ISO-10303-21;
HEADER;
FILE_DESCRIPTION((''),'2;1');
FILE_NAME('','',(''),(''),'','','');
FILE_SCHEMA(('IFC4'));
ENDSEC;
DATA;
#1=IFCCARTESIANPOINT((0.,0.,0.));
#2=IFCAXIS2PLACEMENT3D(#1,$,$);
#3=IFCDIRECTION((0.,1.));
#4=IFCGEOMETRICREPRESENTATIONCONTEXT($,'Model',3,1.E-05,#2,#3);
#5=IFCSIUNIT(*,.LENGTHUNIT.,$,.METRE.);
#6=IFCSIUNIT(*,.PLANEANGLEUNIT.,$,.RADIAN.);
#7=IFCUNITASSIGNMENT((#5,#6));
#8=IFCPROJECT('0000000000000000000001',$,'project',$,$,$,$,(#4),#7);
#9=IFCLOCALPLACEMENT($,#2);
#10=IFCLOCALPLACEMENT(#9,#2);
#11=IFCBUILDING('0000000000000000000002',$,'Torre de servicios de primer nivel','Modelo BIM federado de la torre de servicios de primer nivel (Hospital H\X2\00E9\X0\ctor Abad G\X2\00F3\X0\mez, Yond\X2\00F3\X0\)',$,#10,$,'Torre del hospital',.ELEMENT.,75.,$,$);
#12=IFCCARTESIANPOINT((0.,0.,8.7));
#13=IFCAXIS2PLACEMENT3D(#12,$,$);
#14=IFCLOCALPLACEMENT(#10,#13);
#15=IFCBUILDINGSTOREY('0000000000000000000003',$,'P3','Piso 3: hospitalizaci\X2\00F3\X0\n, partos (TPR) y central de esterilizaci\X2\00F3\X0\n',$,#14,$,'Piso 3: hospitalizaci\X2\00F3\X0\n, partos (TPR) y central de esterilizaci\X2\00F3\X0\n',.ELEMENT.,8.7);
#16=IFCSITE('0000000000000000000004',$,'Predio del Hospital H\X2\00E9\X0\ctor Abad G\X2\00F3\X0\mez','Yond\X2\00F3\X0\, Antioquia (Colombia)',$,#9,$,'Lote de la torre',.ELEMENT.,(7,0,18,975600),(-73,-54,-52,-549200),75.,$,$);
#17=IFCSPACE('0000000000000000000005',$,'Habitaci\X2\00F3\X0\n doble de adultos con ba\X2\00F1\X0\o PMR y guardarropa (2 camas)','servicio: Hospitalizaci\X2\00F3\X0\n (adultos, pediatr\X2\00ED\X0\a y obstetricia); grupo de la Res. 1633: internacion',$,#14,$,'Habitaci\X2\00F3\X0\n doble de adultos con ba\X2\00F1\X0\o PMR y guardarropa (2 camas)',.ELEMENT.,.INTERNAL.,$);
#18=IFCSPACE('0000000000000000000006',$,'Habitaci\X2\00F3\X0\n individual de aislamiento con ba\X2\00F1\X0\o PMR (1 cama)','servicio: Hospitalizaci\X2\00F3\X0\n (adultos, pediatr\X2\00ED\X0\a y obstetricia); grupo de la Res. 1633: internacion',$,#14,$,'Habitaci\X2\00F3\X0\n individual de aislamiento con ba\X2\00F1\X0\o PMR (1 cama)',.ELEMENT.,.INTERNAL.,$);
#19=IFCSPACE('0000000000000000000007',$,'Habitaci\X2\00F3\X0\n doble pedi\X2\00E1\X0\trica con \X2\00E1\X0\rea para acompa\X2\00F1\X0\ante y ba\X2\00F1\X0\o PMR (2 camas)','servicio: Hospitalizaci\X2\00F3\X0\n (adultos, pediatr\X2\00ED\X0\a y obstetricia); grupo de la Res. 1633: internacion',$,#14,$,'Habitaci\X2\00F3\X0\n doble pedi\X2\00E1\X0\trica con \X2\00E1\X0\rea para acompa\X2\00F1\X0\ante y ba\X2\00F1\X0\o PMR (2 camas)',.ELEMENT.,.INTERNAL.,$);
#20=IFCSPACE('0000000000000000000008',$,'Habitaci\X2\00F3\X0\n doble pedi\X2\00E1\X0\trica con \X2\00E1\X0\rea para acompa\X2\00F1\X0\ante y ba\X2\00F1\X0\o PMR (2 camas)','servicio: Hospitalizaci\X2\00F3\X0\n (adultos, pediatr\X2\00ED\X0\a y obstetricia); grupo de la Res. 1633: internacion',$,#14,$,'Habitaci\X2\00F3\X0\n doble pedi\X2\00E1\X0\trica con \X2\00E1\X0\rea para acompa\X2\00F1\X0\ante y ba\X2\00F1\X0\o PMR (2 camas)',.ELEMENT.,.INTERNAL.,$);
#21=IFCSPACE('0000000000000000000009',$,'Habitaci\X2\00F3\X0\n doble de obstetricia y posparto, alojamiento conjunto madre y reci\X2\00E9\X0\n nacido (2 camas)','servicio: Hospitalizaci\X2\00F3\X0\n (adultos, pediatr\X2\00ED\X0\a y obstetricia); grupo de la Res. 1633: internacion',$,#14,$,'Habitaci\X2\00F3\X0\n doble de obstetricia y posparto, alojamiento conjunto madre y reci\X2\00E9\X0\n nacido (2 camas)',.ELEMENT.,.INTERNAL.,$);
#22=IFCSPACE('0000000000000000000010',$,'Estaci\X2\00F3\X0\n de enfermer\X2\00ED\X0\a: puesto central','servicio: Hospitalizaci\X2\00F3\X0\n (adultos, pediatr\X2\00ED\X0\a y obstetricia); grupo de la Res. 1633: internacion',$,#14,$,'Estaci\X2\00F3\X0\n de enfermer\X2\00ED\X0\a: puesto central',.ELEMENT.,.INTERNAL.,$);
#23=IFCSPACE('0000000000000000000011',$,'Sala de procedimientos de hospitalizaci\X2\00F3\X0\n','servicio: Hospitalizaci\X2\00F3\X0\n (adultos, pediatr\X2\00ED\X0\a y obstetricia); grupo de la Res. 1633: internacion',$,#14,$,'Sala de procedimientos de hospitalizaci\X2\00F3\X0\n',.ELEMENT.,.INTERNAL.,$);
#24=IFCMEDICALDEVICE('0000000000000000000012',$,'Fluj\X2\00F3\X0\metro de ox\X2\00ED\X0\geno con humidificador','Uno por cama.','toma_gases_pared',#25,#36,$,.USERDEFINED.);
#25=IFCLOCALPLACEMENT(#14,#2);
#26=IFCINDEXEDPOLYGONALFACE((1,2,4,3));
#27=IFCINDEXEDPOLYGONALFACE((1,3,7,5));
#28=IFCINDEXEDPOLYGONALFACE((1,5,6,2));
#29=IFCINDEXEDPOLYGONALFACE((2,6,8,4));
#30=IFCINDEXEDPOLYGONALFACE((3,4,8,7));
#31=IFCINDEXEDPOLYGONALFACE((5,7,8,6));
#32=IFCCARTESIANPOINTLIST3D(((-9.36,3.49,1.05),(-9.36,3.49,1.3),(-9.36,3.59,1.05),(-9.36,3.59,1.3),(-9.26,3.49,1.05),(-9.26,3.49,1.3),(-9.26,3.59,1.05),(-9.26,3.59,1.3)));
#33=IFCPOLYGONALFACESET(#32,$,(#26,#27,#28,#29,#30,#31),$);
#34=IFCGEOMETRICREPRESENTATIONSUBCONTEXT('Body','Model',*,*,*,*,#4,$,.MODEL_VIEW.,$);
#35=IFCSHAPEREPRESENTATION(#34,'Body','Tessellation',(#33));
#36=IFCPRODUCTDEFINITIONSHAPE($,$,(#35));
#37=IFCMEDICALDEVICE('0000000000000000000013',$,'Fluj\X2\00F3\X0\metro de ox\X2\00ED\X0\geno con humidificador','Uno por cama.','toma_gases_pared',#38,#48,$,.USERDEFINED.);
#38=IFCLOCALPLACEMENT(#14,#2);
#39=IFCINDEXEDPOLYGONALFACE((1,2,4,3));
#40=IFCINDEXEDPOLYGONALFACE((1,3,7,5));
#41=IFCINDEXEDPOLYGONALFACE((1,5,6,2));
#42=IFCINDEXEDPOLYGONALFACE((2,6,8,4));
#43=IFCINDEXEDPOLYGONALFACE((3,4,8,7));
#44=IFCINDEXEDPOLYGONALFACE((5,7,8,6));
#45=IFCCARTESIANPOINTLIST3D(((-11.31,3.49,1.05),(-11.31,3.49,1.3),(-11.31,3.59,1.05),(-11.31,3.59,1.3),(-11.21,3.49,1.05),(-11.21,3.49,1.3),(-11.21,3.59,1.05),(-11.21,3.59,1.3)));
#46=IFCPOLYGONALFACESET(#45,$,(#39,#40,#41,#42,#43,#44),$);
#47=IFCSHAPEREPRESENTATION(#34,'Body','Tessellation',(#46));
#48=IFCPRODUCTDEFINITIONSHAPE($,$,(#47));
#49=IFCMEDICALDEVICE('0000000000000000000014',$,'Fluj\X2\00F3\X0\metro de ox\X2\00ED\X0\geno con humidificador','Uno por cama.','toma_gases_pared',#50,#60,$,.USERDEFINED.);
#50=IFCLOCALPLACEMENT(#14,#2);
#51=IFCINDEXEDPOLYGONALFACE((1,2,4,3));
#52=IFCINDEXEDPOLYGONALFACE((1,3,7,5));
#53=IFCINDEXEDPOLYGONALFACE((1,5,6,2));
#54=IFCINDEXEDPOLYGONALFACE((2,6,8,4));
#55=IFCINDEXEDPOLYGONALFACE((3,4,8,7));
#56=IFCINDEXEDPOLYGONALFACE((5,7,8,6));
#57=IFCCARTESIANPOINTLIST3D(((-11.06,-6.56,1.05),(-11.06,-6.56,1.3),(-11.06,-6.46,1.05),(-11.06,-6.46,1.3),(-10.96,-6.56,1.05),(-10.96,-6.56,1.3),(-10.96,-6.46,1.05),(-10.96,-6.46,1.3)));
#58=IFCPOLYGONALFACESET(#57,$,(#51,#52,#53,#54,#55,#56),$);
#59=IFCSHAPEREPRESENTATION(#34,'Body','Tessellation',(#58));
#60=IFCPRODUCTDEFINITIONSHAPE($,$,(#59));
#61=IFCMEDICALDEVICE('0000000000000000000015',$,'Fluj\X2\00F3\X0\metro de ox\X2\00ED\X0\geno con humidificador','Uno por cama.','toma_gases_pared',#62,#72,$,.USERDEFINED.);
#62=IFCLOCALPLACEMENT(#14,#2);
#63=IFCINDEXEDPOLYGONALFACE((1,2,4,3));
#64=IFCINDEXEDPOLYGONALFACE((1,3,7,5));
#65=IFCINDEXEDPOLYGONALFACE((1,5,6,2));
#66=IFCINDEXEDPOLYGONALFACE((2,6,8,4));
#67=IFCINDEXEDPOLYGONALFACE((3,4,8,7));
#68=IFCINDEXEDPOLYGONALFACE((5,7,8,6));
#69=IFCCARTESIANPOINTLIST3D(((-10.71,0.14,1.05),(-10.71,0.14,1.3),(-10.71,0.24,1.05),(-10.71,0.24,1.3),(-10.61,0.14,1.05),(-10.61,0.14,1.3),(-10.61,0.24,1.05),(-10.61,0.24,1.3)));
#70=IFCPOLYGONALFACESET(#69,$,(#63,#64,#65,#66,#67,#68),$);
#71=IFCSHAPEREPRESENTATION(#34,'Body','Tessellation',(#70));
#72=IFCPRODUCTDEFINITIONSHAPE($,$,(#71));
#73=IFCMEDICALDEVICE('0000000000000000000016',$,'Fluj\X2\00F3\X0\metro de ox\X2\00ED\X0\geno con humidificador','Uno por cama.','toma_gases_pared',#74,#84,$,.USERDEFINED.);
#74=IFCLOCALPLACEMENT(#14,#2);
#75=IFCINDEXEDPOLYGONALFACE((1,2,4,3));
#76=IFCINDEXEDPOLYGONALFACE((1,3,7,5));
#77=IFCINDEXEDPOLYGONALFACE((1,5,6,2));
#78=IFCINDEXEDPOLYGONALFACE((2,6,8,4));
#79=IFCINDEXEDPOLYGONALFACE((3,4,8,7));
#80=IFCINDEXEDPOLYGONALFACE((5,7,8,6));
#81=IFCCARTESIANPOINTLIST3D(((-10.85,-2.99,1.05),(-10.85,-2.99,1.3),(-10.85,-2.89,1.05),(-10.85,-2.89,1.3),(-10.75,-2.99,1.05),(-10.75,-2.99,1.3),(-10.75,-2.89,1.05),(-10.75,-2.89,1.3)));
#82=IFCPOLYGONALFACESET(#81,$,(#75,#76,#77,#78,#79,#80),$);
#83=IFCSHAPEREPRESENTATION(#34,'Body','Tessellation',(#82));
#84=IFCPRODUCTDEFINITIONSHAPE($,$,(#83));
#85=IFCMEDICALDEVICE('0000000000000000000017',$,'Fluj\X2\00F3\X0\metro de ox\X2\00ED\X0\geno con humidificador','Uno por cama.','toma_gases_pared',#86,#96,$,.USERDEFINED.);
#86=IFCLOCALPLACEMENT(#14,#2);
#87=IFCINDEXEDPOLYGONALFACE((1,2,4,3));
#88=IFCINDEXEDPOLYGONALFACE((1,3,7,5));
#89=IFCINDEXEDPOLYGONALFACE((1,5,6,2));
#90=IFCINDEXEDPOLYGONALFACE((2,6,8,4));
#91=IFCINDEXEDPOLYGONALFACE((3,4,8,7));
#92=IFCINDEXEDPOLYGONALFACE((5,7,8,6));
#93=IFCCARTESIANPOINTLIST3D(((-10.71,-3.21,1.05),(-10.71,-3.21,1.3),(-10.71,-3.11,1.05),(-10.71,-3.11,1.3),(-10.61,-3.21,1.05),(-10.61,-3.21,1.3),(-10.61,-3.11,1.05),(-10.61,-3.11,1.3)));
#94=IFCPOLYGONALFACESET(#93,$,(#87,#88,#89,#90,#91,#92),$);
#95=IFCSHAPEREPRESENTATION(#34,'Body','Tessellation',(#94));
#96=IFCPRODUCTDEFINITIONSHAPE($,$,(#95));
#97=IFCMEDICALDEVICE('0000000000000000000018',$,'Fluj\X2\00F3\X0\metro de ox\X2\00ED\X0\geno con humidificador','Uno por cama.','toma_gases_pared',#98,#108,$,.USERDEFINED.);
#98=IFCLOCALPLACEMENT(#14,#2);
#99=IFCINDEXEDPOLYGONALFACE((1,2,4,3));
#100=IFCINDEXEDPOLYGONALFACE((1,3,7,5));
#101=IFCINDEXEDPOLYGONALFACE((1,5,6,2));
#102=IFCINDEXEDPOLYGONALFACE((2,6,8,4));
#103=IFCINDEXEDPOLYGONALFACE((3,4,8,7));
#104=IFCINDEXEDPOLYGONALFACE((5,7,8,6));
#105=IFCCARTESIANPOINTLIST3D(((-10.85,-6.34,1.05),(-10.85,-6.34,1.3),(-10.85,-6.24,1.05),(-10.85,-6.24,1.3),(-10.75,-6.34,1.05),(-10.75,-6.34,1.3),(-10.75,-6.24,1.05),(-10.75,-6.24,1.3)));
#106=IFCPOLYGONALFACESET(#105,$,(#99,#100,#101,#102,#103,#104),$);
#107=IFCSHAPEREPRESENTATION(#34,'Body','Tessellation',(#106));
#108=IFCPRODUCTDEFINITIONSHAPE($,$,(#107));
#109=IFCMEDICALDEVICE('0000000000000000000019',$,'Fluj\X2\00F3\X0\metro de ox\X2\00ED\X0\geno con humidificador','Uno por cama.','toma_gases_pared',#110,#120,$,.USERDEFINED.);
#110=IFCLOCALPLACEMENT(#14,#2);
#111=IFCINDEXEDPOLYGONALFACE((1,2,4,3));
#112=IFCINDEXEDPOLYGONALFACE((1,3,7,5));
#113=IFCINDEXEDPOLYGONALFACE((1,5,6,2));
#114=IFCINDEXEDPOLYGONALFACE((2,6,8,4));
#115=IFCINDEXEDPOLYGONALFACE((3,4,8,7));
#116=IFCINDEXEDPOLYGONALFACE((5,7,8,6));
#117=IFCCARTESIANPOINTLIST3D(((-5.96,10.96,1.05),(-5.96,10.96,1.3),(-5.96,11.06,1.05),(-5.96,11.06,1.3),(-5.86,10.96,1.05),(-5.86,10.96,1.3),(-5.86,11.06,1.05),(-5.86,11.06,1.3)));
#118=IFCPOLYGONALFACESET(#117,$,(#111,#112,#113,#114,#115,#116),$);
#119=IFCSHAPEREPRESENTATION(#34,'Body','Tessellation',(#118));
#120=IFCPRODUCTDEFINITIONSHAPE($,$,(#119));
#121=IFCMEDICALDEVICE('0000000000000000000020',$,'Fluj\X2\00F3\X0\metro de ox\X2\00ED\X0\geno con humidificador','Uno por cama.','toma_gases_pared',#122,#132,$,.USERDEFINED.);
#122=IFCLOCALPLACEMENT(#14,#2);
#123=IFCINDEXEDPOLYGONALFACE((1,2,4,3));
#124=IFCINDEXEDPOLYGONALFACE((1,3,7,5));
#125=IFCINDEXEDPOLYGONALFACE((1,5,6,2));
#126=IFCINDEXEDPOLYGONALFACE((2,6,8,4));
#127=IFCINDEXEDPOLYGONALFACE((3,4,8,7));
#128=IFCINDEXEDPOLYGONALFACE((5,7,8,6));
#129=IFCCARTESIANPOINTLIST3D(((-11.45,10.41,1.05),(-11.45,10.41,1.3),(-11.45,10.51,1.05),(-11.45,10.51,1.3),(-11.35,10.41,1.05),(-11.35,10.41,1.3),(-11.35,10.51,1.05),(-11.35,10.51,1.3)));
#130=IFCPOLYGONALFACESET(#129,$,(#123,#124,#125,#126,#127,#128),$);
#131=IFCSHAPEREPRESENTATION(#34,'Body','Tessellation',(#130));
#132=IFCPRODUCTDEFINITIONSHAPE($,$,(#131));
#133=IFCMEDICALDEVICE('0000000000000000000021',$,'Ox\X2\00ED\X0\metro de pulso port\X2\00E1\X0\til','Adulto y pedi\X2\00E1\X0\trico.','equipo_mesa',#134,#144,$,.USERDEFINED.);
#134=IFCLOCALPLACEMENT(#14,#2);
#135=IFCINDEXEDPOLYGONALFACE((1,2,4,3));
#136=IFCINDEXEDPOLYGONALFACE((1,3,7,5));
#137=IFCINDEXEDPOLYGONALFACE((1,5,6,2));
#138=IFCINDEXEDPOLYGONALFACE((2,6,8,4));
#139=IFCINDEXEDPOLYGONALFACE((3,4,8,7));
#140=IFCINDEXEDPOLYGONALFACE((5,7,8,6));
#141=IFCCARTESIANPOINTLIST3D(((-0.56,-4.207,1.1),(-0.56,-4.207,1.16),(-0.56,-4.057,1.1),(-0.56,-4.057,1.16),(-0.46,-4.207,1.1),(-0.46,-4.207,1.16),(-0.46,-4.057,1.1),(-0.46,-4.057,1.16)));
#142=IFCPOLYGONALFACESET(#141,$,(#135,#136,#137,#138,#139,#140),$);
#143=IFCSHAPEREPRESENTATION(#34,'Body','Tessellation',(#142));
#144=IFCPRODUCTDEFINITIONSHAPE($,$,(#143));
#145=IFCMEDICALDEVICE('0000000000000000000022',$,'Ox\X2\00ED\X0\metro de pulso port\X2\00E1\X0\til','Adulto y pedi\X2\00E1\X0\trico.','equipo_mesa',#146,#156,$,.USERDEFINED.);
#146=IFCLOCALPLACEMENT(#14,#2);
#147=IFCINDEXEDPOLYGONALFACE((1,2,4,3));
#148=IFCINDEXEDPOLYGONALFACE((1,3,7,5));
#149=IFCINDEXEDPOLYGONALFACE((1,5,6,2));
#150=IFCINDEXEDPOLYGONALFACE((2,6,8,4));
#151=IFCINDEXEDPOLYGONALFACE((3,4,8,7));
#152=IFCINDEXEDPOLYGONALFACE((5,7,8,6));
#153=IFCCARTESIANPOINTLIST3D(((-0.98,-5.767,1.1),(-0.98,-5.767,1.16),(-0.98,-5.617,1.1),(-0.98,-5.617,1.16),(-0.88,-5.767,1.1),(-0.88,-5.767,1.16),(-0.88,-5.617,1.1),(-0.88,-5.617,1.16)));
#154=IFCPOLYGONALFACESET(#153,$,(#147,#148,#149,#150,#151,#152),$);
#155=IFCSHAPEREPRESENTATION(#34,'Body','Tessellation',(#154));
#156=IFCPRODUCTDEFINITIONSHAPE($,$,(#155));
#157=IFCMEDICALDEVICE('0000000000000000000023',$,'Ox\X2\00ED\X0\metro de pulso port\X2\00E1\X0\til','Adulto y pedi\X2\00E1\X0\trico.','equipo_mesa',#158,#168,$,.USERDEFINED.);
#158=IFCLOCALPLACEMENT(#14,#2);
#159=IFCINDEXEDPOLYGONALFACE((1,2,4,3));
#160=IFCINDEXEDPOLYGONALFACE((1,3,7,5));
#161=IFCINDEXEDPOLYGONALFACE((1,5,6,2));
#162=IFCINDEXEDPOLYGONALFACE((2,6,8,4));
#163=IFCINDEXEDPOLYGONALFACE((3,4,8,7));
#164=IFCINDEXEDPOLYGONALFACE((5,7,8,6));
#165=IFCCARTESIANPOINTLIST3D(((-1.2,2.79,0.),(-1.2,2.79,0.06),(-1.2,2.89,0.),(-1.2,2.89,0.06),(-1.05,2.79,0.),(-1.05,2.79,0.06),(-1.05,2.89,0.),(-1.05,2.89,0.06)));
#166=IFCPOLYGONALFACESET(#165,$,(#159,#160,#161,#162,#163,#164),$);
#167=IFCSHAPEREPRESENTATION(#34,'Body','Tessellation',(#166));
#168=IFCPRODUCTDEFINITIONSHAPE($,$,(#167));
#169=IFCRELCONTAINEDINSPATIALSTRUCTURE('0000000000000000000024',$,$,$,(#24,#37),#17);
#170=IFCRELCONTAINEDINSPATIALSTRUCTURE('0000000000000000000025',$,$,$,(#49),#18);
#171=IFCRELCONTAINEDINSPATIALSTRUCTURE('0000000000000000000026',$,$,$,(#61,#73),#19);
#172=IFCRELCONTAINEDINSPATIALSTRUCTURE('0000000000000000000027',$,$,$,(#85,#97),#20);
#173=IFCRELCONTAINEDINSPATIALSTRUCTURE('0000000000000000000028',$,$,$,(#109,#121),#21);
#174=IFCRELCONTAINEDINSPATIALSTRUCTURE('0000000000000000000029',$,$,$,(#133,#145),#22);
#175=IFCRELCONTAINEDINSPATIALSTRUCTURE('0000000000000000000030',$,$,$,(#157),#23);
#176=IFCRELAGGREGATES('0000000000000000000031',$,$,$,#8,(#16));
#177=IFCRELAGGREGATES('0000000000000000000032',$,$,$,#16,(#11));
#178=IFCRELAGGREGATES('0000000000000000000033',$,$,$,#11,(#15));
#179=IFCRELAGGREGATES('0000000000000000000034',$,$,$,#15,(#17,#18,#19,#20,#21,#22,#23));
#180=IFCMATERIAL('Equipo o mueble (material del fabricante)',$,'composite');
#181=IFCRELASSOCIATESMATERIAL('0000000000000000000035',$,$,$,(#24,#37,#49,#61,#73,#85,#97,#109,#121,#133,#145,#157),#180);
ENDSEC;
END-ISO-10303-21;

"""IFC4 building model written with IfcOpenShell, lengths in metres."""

from ifc_helpers import new_model, si_unit, direction, frame, origin, place, context, subcontext, project, spatial, rectangle, extrude, material, element, save


model = new_model("IFC4")

# Units and contexts
model_context = context("Model", 3, precision=1e-05, world=origin(), true_north=direction((0.0, 1.0)))
body_context = subcontext(model_context, "Body", "Model", "MODEL_VIEW")
ifc_project = project(units=[si_unit("LENGTHUNIT", "METRE"), si_unit("PLANEANGLEUNIT", "RADIAN")], contexts=[model_context])

# Site, building, storey
site_placement = place(None, origin())
site = spatial("IfcSite", under=ifc_project, at=site_placement, Name="Predio del Hospital Héctor Abad Gómez", Description="Yondó, Antioquia (Colombia)", LongName="Lote de la torre", CompositionType="ELEMENT", RefLatitude=(7, 0, 18, 975600), RefLongitude=(-73, -54, -52, -549200), RefElevation=75.0)
building_placement = place(site_placement, origin())
building = spatial("IfcBuilding", under=site, at=building_placement, Name="Torre de servicios de primer nivel", Description="Modelo BIM federado de la torre de servicios de primer nivel (Hospital Héctor Abad Gómez, Yondó)", LongName="Torre del hospital", CompositionType="ELEMENT", ElevationOfRefHeight=75.0)
placement = place(building_placement, frame((0.0, 0.0, 8.7)))
storey = spatial("IfcBuildingStorey", under=building, at=placement, Name="P3", Description="Piso 3: hospitalización, partos (TPR) y central de esterilización", LongName="Piso 3: hospitalización, partos (TPR) y central de esterilización", CompositionType="ELEMENT", Elevation=8.7)

# Shared definitions
ifc_material = material(Name="Equipo o mueble (material del fabricante)", Category="composite")

# Shared definitions
space_1 = spatial("IfcSpace", under=storey, at=placement, Name="Habitación doble de adultos con baño PMR y guardarropa (2 camas)", Description="servicio: Hospitalización (adultos, pediatría y obstetricia); grupo de la Res. 1633: internacion", LongName="Habitación doble de adultos con baño PMR y guardarropa (2 camas)", CompositionType="ELEMENT", PredefinedType="INTERNAL")

# Shared definitions
space_2 = spatial("IfcSpace", under=storey, at=placement, Name="Habitación individual de aislamiento con baño PMR (1 cama)", Description="servicio: Hospitalización (adultos, pediatría y obstetricia); grupo de la Res. 1633: internacion", LongName="Habitación individual de aislamiento con baño PMR (1 cama)", CompositionType="ELEMENT", PredefinedType="INTERNAL")

# Shared definitions
space_3 = spatial("IfcSpace", under=storey, at=placement, Name="Habitación doble pediátrica con área para acompañante y baño PMR (2 camas)", Description="servicio: Hospitalización (adultos, pediatría y obstetricia); grupo de la Res. 1633: internacion", LongName="Habitación doble pediátrica con área para acompañante y baño PMR (2 camas)", CompositionType="ELEMENT", PredefinedType="INTERNAL")

# Shared definitions
space_4 = spatial("IfcSpace", under=storey, at=placement, Name="Habitación doble pediátrica con área para acompañante y baño PMR (2 camas)", Description="servicio: Hospitalización (adultos, pediatría y obstetricia); grupo de la Res. 1633: internacion", LongName="Habitación doble pediátrica con área para acompañante y baño PMR (2 camas)", CompositionType="ELEMENT", PredefinedType="INTERNAL")

# Shared definitions
space_5 = spatial("IfcSpace", under=storey, at=placement, Name="Habitación doble de obstetricia y posparto, alojamiento conjunto madre y recién nacido (2 camas)", Description="servicio: Hospitalización (adultos, pediatría y obstetricia); grupo de la Res. 1633: internacion", LongName="Habitación doble de obstetricia y posparto, alojamiento conjunto madre y recién nacido (2 camas)", CompositionType="ELEMENT", PredefinedType="INTERNAL")

# Medical devices
element("IfcMedicalDevice", 1, at=placement, inside=space_1, material=ifc_material, Name="Flujómetro de oxígeno con humidificador", Description="Uno por cama.", ObjectType="toma_gases_pared", PredefinedType="USERDEFINED", context=body_context, shape_type="SweptSolid", body=[
    extrude(rectangle(XDim=0.1, YDim=0.1), frame((-9.31, 3.54, 1.05), z_axis=(0.0, 0.0, 1.0), x_axis=(-1.0, 0.0, 0.0)), (0.0, 0.0, 1.0), 0.25),
])
element("IfcMedicalDevice", 2, at=placement, inside=space_1, material=ifc_material, Name="Flujómetro de oxígeno con humidificador", Description="Uno por cama.", ObjectType="toma_gases_pared", PredefinedType="USERDEFINED", context=body_context, shape_type="SweptSolid", body=[
    extrude(rectangle(XDim=0.1, YDim=0.1), frame((-11.26, 3.54, 1.05), z_axis=(0.0, 0.0, 1.0), x_axis=(-1.0, 0.0, 0.0)), (0.0, 0.0, 1.0), 0.25),
])
element("IfcMedicalDevice", 3, at=placement, inside=space_2, material=ifc_material, Name="Flujómetro de oxígeno con humidificador", Description="Uno por cama.", ObjectType="toma_gases_pared", PredefinedType="USERDEFINED", context=body_context, shape_type="SweptSolid", body=[
    extrude(rectangle(XDim=0.1, YDim=0.1), frame((-11.01, -6.51, 1.05), z_axis=(0.0, 0.0, 1.0), x_axis=(-1.0, 0.0, 0.0)), (0.0, 0.0, 1.0), 0.25),
])
element("IfcMedicalDevice", 4, at=placement, inside=space_3, material=ifc_material, Name="Flujómetro de oxígeno con humidificador", Description="Uno por cama.", ObjectType="toma_gases_pared", PredefinedType="USERDEFINED", context=body_context, shape_type="SweptSolid", body=[
    extrude(rectangle(XDim=0.1, YDim=0.1), frame((-10.66, 0.19, 1.05), z_axis=(0.0, 0.0, 1.0), x_axis=(-1.0, 0.0, 0.0)), (0.0, 0.0, 1.0), 0.25),
])
element("IfcMedicalDevice", 5, at=placement, inside=space_3, material=ifc_material, Name="Flujómetro de oxígeno con humidificador", Description="Uno por cama.", ObjectType="toma_gases_pared", PredefinedType="USERDEFINED", context=body_context, shape_type="SweptSolid", body=[
    extrude(rectangle(XDim=0.1, YDim=0.1), frame((-10.8, -2.94, 1.05)), (0.0, 0.0, 1.0), 0.25),
])
element("IfcMedicalDevice", 6, at=placement, inside=space_4, material=ifc_material, Name="Flujómetro de oxígeno con humidificador", Description="Uno por cama.", ObjectType="toma_gases_pared", PredefinedType="USERDEFINED", context=body_context, shape_type="SweptSolid", body=[
    extrude(rectangle(XDim=0.1, YDim=0.1), frame((-10.66, -3.16, 1.05), z_axis=(0.0, 0.0, 1.0), x_axis=(-1.0, 0.0, 0.0)), (0.0, 0.0, 1.0), 0.25),
])
element("IfcMedicalDevice", 7, at=placement, inside=space_4, material=ifc_material, Name="Flujómetro de oxígeno con humidificador", Description="Uno por cama.", ObjectType="toma_gases_pared", PredefinedType="USERDEFINED", context=body_context, shape_type="SweptSolid", body=[
    extrude(rectangle(XDim=0.1, YDim=0.1), frame((-10.8, -6.29, 1.05)), (0.0, 0.0, 1.0), 0.25),
])
element("IfcMedicalDevice", 8, at=placement, inside=space_5, material=ifc_material, Name="Flujómetro de oxígeno con humidificador", Description="Uno por cama.", ObjectType="toma_gases_pared", PredefinedType="USERDEFINED", context=body_context, shape_type="SweptSolid", body=[
    extrude(rectangle(XDim=0.1, YDim=0.1), frame((-5.91, 11.01, 1.05), z_axis=(0.0, 0.0, 1.0), x_axis=(0.0, 1.0, 0.0)), (0.0, 0.0, 1.0), 0.25),
])
element("IfcMedicalDevice", 9, at=placement, inside=space_5, material=ifc_material, Name="Flujómetro de oxígeno con humidificador", Description="Uno por cama.", ObjectType="toma_gases_pared", PredefinedType="USERDEFINED", context=body_context, shape_type="SweptSolid", body=[
    extrude(rectangle(XDim=0.1, YDim=0.1), frame((-11.4, 10.46, 1.05)), (0.0, 0.0, 1.0), 0.25),
])

# Shared definitions
space_6 = spatial("IfcSpace", under=storey, at=placement, Name="Estación de enfermería: puesto central", Description="servicio: Hospitalización (adultos, pediatría y obstetricia); grupo de la Res. 1633: internacion", LongName="Estación de enfermería: puesto central", CompositionType="ELEMENT", PredefinedType="INTERNAL")

# Medical devices
element("IfcMedicalDevice", 10, at=placement, inside=space_6, material=ifc_material, Name="Oxímetro de pulso portátil", Description="Adulto y pediátrico.", ObjectType="equipo_mesa", PredefinedType="USERDEFINED", context=body_context, shape_type="SweptSolid", body=[
    extrude(rectangle(XDim=0.15, YDim=0.1), frame((-0.51, -4.132, 1.1), z_axis=(0.0, 0.0, 1.0), x_axis=(0.0, 1.0, 0.0)), (0.0, 0.0, 1.0), 0.06),
])
element("IfcMedicalDevice", 11, at=placement, inside=space_6, material=ifc_material, Name="Oxímetro de pulso portátil", Description="Adulto y pediátrico.", ObjectType="equipo_mesa", PredefinedType="USERDEFINED", context=body_context, shape_type="SweptSolid", body=[
    extrude(rectangle(XDim=0.15, YDim=0.1), frame((-0.93, -5.692, 1.1), z_axis=(0.0, 0.0, 1.0), x_axis=(0.0, 1.0, 0.0)), (0.0, 0.0, 1.0), 0.06),
])

# Shared definitions
space_7 = spatial("IfcSpace", under=storey, at=placement, Name="Sala de procedimientos de hospitalización", Description="servicio: Hospitalización (adultos, pediatría y obstetricia); grupo de la Res. 1633: internacion", LongName="Sala de procedimientos de hospitalización", CompositionType="ELEMENT", PredefinedType="INTERNAL")

# Medical device
element("IfcMedicalDevice", 12, at=placement, inside=space_7, material=ifc_material, Name="Oxímetro de pulso portátil", Description="Adulto y pediátrico.", ObjectType="equipo_mesa", PredefinedType="USERDEFINED", context=body_context, shape_type="SweptSolid", body=[
    extrude(rectangle(XDim=0.15, YDim=0.1), frame((-1.125, 2.84, 0.0), z_axis=(0.0, 0.0, 1.0), x_axis=(-1.0, 0.0, 0.0)), (0.0, 0.0, 1.0), 0.06),
])

save(model, "model.ifc")
